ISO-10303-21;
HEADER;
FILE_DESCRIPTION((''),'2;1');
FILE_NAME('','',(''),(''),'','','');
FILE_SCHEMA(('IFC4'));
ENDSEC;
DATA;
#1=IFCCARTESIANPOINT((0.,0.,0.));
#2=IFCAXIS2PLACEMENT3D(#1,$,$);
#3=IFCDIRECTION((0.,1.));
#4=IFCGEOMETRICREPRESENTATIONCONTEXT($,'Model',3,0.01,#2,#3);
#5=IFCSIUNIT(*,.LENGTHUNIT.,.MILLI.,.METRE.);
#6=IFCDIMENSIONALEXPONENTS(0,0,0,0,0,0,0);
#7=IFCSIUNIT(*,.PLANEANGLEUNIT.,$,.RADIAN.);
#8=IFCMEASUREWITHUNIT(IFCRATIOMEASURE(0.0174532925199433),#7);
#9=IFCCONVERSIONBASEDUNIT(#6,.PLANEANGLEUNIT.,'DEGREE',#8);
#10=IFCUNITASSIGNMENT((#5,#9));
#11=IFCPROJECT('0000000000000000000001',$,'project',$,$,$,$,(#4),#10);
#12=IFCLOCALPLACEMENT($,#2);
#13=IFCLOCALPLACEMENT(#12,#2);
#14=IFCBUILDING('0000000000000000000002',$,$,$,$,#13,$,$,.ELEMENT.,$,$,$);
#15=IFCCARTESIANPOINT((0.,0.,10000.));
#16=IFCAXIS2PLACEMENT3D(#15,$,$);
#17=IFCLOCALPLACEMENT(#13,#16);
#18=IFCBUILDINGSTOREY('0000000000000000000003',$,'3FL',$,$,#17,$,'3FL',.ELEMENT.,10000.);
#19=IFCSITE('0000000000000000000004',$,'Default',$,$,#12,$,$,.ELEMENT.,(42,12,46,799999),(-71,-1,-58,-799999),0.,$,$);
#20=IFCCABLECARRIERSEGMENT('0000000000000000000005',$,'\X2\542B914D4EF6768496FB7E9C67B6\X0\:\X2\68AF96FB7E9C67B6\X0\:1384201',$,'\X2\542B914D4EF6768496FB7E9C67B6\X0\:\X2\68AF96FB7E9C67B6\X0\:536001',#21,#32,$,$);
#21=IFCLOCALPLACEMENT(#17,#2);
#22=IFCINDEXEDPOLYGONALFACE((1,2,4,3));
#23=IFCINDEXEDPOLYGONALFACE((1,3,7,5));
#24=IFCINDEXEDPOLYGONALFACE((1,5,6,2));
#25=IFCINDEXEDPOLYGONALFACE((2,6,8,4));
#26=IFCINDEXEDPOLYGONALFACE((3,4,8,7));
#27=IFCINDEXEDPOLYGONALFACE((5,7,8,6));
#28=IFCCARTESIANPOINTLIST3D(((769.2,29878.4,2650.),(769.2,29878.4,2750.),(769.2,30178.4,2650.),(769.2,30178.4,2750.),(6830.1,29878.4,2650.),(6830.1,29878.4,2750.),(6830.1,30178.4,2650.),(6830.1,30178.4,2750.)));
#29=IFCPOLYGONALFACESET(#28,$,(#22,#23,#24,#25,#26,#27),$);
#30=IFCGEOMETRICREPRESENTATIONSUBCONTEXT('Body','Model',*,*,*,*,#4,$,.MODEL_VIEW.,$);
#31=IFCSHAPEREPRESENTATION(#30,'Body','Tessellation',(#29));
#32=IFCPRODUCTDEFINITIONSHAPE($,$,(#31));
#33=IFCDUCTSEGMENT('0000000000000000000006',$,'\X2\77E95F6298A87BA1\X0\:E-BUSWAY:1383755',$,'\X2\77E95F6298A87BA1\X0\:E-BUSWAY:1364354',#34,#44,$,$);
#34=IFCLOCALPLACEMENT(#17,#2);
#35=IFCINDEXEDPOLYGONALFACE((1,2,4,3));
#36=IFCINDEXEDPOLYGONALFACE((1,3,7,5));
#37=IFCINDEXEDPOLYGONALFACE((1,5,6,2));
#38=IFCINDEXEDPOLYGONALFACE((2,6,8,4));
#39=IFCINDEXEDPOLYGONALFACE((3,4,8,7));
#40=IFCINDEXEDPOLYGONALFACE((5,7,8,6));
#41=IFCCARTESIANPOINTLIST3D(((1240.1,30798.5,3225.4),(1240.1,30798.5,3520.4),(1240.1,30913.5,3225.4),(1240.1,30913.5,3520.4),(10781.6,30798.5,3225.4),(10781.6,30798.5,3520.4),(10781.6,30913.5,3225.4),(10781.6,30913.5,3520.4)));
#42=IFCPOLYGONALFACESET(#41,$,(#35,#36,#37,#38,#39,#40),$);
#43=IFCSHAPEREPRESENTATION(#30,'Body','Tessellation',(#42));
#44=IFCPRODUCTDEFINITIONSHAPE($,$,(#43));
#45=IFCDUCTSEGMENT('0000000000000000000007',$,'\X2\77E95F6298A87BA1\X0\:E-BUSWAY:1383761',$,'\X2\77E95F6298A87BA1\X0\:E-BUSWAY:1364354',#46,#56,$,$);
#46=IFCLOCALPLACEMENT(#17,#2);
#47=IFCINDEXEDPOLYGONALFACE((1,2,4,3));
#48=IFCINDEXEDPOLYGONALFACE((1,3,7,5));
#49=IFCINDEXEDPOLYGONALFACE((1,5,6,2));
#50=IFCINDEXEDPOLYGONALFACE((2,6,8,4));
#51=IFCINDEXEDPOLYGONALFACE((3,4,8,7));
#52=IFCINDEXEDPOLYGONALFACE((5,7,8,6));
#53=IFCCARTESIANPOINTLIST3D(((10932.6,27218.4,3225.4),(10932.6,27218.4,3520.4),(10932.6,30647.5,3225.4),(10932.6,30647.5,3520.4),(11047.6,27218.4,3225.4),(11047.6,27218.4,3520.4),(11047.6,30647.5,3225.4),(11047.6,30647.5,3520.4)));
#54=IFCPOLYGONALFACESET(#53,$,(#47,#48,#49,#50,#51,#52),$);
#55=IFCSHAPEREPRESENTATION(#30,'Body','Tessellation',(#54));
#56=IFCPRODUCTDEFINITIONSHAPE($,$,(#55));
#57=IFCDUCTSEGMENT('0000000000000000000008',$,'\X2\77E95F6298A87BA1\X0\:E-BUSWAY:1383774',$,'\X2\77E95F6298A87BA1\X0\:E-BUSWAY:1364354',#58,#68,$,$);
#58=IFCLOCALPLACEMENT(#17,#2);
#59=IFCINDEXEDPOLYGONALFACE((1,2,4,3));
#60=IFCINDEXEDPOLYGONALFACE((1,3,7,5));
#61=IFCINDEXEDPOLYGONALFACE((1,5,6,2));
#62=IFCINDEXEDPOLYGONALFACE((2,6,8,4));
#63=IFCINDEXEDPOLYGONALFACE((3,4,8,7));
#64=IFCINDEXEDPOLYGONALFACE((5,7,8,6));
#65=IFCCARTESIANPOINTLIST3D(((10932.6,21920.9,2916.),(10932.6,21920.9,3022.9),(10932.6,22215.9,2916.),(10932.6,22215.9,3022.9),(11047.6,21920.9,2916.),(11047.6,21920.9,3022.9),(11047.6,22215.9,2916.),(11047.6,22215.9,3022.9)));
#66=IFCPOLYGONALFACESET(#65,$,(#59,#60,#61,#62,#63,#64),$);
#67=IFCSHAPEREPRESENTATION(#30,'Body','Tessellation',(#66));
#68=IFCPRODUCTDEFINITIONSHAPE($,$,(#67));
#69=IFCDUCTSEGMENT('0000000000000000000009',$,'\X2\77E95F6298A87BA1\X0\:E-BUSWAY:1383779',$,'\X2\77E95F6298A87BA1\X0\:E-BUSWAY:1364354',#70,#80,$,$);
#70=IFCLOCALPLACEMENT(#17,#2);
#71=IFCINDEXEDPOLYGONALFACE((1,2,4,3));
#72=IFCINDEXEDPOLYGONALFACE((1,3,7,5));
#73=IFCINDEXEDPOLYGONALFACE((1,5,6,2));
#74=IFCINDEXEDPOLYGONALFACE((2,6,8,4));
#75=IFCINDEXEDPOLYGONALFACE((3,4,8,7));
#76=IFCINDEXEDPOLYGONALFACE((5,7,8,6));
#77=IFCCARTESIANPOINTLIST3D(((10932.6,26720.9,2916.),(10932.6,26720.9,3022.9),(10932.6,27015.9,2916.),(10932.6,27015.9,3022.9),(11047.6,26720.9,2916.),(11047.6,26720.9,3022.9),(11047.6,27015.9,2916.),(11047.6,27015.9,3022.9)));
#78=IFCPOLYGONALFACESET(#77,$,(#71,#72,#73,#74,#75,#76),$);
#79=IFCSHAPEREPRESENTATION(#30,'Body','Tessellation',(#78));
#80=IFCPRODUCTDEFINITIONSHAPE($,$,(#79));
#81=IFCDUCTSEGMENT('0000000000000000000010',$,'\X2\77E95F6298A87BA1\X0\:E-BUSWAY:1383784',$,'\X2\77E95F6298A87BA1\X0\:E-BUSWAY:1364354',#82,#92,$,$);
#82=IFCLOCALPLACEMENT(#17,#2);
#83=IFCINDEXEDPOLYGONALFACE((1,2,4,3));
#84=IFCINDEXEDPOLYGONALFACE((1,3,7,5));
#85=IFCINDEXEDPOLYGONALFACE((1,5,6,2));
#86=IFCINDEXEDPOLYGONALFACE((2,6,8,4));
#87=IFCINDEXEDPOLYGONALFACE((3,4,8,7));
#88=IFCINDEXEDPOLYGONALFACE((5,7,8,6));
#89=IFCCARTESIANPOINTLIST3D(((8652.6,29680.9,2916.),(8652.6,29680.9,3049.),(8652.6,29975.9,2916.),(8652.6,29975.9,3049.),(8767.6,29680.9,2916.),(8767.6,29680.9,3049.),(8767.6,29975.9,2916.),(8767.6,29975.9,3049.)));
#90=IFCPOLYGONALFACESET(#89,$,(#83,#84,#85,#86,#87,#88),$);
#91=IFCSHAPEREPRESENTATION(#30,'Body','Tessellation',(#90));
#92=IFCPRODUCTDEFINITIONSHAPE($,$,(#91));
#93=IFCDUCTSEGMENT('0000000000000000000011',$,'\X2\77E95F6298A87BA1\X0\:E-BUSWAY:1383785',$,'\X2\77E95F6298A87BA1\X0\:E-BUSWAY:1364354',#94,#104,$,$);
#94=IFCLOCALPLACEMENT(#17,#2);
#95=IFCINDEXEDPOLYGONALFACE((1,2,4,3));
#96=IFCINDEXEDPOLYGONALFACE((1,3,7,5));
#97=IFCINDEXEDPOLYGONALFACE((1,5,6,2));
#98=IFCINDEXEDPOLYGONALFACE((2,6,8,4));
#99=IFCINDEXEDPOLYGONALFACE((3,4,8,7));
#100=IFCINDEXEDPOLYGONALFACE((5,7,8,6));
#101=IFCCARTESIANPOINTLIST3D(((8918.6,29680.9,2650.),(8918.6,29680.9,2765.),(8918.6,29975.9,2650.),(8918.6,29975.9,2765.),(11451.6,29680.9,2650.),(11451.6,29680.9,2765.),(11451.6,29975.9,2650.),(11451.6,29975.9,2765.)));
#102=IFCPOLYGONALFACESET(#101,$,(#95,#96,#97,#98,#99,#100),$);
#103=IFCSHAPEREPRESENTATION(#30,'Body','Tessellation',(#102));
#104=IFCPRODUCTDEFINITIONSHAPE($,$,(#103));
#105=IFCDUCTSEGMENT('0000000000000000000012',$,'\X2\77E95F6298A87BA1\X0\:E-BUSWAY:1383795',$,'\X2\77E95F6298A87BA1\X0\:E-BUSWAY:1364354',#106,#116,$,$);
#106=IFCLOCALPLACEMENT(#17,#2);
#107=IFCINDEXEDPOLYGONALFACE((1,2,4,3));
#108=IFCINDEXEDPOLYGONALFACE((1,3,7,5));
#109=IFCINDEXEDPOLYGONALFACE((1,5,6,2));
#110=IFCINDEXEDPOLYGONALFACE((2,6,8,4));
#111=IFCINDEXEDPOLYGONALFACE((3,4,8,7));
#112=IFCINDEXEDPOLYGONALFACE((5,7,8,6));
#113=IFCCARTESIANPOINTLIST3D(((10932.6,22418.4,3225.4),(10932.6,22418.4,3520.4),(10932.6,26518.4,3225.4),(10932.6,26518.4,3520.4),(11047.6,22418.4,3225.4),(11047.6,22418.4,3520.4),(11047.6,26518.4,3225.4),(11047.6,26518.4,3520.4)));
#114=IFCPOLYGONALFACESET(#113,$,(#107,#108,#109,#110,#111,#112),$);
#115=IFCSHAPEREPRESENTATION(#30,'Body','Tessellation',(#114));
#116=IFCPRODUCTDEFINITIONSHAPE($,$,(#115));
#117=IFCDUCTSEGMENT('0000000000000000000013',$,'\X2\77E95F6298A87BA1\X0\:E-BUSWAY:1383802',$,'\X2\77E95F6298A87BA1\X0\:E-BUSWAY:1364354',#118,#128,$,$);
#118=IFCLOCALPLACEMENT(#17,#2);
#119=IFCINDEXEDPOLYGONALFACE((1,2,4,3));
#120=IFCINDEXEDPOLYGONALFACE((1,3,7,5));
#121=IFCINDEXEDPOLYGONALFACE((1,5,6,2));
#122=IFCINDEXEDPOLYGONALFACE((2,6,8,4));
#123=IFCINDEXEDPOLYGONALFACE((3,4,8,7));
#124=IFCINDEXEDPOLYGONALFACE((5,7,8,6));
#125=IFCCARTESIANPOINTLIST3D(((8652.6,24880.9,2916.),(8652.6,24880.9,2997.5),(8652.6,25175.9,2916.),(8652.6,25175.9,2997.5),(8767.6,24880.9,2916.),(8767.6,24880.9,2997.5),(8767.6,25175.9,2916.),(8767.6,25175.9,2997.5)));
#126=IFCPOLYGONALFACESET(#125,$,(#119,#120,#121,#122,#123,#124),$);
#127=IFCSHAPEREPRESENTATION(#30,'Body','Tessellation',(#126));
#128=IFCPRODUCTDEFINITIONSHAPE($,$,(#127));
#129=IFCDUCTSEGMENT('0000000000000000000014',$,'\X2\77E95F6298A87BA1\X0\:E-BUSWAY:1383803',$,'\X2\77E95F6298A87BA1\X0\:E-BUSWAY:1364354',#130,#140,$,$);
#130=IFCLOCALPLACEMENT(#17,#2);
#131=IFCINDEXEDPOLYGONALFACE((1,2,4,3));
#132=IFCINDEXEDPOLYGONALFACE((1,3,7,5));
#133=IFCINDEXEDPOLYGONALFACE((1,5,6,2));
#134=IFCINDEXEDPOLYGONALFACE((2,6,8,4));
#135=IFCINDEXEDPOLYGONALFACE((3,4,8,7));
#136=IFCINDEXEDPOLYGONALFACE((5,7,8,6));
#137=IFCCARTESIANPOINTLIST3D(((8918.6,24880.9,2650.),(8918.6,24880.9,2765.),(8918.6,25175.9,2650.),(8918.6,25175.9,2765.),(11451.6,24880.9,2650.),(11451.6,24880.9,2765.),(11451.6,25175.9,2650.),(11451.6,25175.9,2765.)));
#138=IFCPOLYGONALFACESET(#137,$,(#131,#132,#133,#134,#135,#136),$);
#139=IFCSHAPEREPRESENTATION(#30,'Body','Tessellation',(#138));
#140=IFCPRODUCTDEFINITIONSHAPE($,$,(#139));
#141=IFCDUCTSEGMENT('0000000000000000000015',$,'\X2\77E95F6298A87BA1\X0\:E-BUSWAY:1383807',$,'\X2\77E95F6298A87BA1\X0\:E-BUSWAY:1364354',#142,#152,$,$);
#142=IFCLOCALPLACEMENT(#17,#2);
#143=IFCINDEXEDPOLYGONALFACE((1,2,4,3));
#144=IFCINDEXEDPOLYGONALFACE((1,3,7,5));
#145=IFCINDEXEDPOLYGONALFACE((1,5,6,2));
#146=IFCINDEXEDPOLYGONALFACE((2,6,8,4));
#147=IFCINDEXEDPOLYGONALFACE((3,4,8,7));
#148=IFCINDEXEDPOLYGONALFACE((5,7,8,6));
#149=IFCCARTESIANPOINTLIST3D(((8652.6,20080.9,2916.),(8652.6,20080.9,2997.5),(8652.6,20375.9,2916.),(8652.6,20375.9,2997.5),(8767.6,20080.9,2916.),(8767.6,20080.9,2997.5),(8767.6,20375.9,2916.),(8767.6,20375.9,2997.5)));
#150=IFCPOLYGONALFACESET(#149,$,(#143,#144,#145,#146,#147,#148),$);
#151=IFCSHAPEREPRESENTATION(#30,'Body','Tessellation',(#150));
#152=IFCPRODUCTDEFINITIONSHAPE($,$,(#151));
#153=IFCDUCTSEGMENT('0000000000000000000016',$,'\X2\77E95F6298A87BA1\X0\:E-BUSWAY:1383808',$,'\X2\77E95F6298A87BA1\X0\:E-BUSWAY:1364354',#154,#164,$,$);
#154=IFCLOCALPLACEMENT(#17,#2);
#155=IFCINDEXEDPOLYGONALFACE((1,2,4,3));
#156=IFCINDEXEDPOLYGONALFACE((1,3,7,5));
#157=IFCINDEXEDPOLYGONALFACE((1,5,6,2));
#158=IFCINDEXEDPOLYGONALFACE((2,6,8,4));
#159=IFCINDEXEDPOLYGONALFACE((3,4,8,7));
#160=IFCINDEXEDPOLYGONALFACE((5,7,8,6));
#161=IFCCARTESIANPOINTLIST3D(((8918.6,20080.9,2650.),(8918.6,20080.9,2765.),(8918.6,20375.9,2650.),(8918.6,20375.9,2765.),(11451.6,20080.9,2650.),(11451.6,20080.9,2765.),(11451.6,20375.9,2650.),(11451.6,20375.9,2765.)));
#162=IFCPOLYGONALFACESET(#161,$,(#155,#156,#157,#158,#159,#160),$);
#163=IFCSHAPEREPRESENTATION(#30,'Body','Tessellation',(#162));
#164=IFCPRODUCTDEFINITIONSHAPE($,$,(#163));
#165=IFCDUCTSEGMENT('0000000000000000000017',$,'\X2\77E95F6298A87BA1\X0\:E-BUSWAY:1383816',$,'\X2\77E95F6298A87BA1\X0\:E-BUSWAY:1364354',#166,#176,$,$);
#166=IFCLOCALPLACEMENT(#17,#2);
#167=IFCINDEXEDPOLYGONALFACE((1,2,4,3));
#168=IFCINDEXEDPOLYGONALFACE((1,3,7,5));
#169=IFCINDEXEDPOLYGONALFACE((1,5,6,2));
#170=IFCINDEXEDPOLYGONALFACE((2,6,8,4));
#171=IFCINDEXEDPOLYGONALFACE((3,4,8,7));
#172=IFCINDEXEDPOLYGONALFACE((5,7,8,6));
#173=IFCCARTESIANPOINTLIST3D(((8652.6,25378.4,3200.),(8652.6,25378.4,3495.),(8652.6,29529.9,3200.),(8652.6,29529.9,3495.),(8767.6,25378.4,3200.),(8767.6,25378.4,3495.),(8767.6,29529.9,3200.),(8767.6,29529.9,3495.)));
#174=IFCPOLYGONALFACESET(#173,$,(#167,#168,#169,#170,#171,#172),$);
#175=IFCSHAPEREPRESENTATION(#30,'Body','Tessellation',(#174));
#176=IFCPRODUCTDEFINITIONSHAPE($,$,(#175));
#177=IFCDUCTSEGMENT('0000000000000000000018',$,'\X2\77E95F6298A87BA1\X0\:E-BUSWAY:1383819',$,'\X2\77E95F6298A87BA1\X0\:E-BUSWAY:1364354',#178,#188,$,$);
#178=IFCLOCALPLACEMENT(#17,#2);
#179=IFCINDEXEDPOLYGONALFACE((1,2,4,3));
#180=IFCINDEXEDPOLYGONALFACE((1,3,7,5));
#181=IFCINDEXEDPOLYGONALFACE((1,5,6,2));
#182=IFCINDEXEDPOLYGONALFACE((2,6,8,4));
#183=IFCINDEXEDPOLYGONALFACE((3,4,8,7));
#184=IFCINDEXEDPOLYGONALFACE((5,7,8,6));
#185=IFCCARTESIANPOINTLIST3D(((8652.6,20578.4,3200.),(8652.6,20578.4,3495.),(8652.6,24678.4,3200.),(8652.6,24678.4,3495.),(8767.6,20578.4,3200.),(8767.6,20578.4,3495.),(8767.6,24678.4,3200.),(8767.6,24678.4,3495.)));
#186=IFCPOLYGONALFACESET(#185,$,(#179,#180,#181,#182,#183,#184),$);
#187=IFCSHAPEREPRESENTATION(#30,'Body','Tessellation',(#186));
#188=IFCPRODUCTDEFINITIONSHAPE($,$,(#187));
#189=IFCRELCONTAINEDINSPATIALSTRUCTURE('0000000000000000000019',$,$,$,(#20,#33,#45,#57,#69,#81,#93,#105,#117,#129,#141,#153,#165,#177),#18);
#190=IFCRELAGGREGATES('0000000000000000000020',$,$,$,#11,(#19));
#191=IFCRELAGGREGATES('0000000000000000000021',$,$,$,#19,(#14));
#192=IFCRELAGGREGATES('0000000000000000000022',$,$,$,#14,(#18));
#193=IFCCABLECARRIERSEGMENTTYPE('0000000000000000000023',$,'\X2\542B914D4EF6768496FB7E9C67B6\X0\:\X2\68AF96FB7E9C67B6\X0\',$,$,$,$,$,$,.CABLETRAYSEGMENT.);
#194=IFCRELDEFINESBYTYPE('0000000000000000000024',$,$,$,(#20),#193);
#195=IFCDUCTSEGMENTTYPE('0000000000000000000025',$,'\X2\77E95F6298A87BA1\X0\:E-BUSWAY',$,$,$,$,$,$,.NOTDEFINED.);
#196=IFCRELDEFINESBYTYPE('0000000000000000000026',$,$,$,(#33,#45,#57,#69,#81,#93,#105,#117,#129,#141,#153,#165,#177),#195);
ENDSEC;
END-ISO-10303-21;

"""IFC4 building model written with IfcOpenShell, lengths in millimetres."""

from ifc_helpers import new_model, entity, si_unit, converted_unit, direction, frame, frame_2d, origin, origin_2d_with_axis, place, context, subcontext, project, spatial, rectangle, extrude, type_object, element, save


model = new_model("IFC4")

# Units and contexts
model_context = context("Model", 3, precision=0.01, world=origin(), true_north=direction((0.0, 1.0)))
body_context = subcontext(model_context, "Body", "Model", "MODEL_VIEW")
ifc_project = project(units=[si_unit("LENGTHUNIT", "METRE", prefix="MILLI"), converted_unit("PLANEANGLEUNIT", "DEGREE", entity("IfcRatioMeasure", 0.0174532925199433), si_unit("PLANEANGLEUNIT", "RADIAN"), dimensions=[0, 0, 0, 0, 0, 0, 0])], contexts=[model_context])

# Site, building, storey
site_placement = place(None, origin())
site = spatial("IfcSite", under=ifc_project, at=site_placement, Name="Default", CompositionType="ELEMENT", RefLatitude=(42, 12, 46, 799999), RefLongitude=(-71, -1, -58, -799999), RefElevation=0.0)
building_placement = place(site_placement, origin())
building = spatial("IfcBuilding", under=site, at=building_placement, CompositionType="ELEMENT")
storey_placement = place(building_placement, frame((0.0, 0.0, 10000.0)))
storey = spatial("IfcBuildingStorey", under=building, at=storey_placement, Name="3FL", LongName="3FL", CompositionType="ELEMENT", Elevation=10000.0)

# Cable carrier segment
cable_carrier_segment_type = type_object("IfcCableCarrierSegmentType", Name="含配件的電纜架:梯電纜架", PredefinedType="CABLETRAYSEGMENT")
cable_carrier_segment_placement = place(storey_placement, frame((769.2, 29878.4, 2650.0)))
element("IfcCableCarrierSegment", 1, at=cable_carrier_segment_placement, inside=storey, type_object=cable_carrier_segment_type, Name="含配件的電纜架:梯電纜架:1384201", ObjectType="含配件的電纜架:梯電纜架:536001", context=body_context, shape_type="SweptSolid", body=[
    extrude(rectangle(XDim=300.0, YDim=6060.9, at=frame_2d((0.0, 0.0), x_axis=(1.0, 0.0))), frame((3030.5, 150.0, 0.0), z_axis=(0.0, 0.0, 1.0), x_axis=(0.0, -1.0, 0.0)), (0.0, 0.0, 1.0), 100.0),
])

# Duct segments
duct_segment_type = type_object("IfcDuctSegmentType", Name="矩形風管:E-BUSWAY", PredefinedType="NOTDEFINED")
duct_segment_1_placement = place(storey_placement, frame((1240.1, 30798.5, 3225.4)))
element("IfcDuctSegment", 2, at=duct_segment_1_placement, inside=storey, type_object=duct_segment_type, Name="矩形風管:E-BUSWAY:1383755", ObjectType="矩形風管:E-BUSWAY:1364354", context=body_context, shape_type="SweptSolid", body=[
    extrude(rectangle(XDim=9541.5, YDim=115.0, at=frame_2d((0.0, 0.0), x_axis=(1.0, 0.0))), frame((4770.8, 57.5, 0.0), z_axis=(0.0, 0.0, 1.0), x_axis=(-1.0, 0.0, 0.0)), (0.0, 0.0, 1.0), 295.0),
])
duct_segment_2_placement = place(storey_placement, frame((10932.6, 27218.4, 3225.4)))
element("IfcDuctSegment", 3, at=duct_segment_2_placement, inside=storey, type_object=duct_segment_type, Name="矩形風管:E-BUSWAY:1383761", ObjectType="矩形風管:E-BUSWAY:1364354", context=body_context, shape_type="SweptSolid", body=[
    extrude(rectangle(XDim=3429.1, YDim=115.0, at=frame_2d((0.0, 0.0), x_axis=(1.0, 0.0))), frame((57.5, 1714.5, 0.0), z_axis=(0.0, 0.0, 1.0), x_axis=(0.0, 1.0, 0.0)), (0.0, 0.0, 1.0), 295.0),
])
duct_segment_3_placement = place(storey_placement, frame((10932.6, 21920.9, 2916.0)))
element("IfcDuctSegment", 4, at=duct_segment_3_placement, inside=storey, type_object=duct_segment_type, Name="矩形風管:E-BUSWAY:1383774", ObjectType="矩形風管:E-BUSWAY:1364354", context=body_context, shape_type="SweptSolid", body=[
    extrude(rectangle(XDim=115.0, YDim=295.0, at=frame_2d((0.0, 0.0), x_axis=(1.0, 0.0))), frame((57.5, 147.5, 0.0), z_axis=(0.0, 0.0, 1.0), x_axis=(-1.0, 0.0, 0.0)), (0.0, 0.0, 1.0), 106.9),
])
duct_segment_4_placement = place(storey_placement, frame((10932.6, 26720.9, 2916.0)))
element("IfcDuctSegment", 5, at=duct_segment_4_placement, inside=storey, type_object=duct_segment_type, Name="矩形風管:E-BUSWAY:1383779", ObjectType="矩形風管:E-BUSWAY:1364354", context=body_context, shape_type="SweptSolid", body=[
    extrude(rectangle(XDim=115.0, YDim=295.0, at=frame_2d((0.0, 0.0), x_axis=(1.0, 0.0))), frame((57.5, 147.5, 0.0), z_axis=(0.0, 0.0, 1.0), x_axis=(-1.0, 0.0, 0.0)), (0.0, 0.0, 1.0), 106.9),
])
duct_segment_5_placement = place(storey_placement, frame((8652.6, 29680.9, 2916.0)))
element("IfcDuctSegment", 6, at=duct_segment_5_placement, inside=storey, type_object=duct_segment_type, Name="矩形風管:E-BUSWAY:1383784", ObjectType="矩形風管:E-BUSWAY:1364354", context=body_context, shape_type="SweptSolid", body=[
    extrude(rectangle(XDim=115.0, YDim=295.0, at=frame_2d((0.0, 0.0), x_axis=(1.0, 0.0))), frame((57.5, 147.5, 0.0), z_axis=(0.0, 0.0, 1.0), x_axis=(-1.0, 0.0, 0.0)), (0.0, 0.0, 1.0), 133.0),
])
duct_segment_6_placement = place(storey_placement, frame((8918.6, 29680.9, 2650.0)))
element("IfcDuctSegment", 7, at=duct_segment_6_placement, inside=storey, type_object=duct_segment_type, Name="矩形風管:E-BUSWAY:1383785", ObjectType="矩形風管:E-BUSWAY:1364354", context=body_context, shape_type="SweptSolid", body=[
    extrude(rectangle(XDim=2533.0, YDim=295.0, at=frame_2d((0.0, 0.0), x_axis=(1.0, 0.0))), frame((1266.5, 147.5, 0.0)), (0.0, 0.0, 1.0), 115.0),
])
duct_segment_7_placement = place(storey_placement, frame((10932.6, 22418.4, 3225.4)))
element("IfcDuctSegment", 8, at=duct_segment_7_placement, inside=storey, type_object=duct_segment_type, Name="矩形風管:E-BUSWAY:1383795", ObjectType="矩形風管:E-BUSWAY:1364354", context=body_context, shape_type="SweptSolid", body=[
    extrude(rectangle(XDim=4100.0, YDim=115.0, at=frame_2d((0.0, 0.0), x_axis=(1.0, 0.0))), frame((57.5, 2050.0, 0.0), z_axis=(0.0, 0.0, 1.0), x_axis=(0.0, 1.0, 0.0)), (0.0, 0.0, 1.0), 295.0),
])
duct_segment_8_placement = place(storey_placement, frame((8652.6, 24880.9, 2916.0)))
element("IfcDuctSegment", 9, at=duct_segment_8_placement, inside=storey, type_object=duct_segment_type, Name="矩形風管:E-BUSWAY:1383802", ObjectType="矩形風管:E-BUSWAY:1364354", context=body_context, shape_type="SweptSolid", body=[
    extrude(rectangle(XDim=115.0, YDim=295.0, at=frame_2d((0.0, 0.0), x_axis=(1.0, 0.0))), frame((57.5, 147.5, 0.0), z_axis=(0.0, 0.0, 1.0), x_axis=(-1.0, 0.0, 0.0)), (0.0, 0.0, 1.0), 81.5),
])
duct_segment_9_placement = place(storey_placement, frame((8918.6, 24880.9, 2650.0)))
element("IfcDuctSegment", 10, at=duct_segment_9_placement, inside=storey, type_object=duct_segment_type, Name="矩形風管:E-BUSWAY:1383803", ObjectType="矩形風管:E-BUSWAY:1364354", context=body_context, shape_type="SweptSolid", body=[
    extrude(rectangle(XDim=2533.0, YDim=295.0, at=frame_2d((0.0, 0.0), x_axis=(1.0, 0.0))), frame((1266.5, 147.5, 0.0)), (0.0, 0.0, 1.0), 115.0),
])
duct_segment_10_placement = place(storey_placement, frame((8652.6, 20080.9, 2916.0)))
element("IfcDuctSegment", 11, at=duct_segment_10_placement, inside=storey, type_object=duct_segment_type, Name="矩形風管:E-BUSWAY:1383807", ObjectType="矩形風管:E-BUSWAY:1364354", context=body_context, shape_type="SweptSolid", body=[
    extrude(rectangle(XDim=115.0, YDim=295.0, at=frame_2d((0.0, 0.0), x_axis=(1.0, 0.0))), frame((57.5, 147.5, 0.0), z_axis=(0.0, 0.0, 1.0), x_axis=(-1.0, 0.0, 0.0)), (0.0, 0.0, 1.0), 81.5),
])
duct_segment_11_placement = place(storey_placement, frame((8918.6, 20080.9, 2650.0)))
element("IfcDuctSegment", 12, at=duct_segment_11_placement, inside=storey, type_object=duct_segment_type, Name="矩形風管:E-BUSWAY:1383808", ObjectType="矩形風管:E-BUSWAY:1364354", context=body_context, shape_type="SweptSolid", body=[
    extrude(rectangle(XDim=2533.0, YDim=295.0, at=origin_2d_with_axis()), frame((1266.5, 147.5, 0.0)), (0.0, 0.0, 1.0), 115.0),
])
duct_segment_12_placement = place(storey_placement, frame((8652.6, 25378.4, 3200.0)))
element("IfcDuctSegment", 13, at=duct_segment_12_placement, inside=storey, type_object=duct_segment_type, Name="矩形風管:E-BUSWAY:1383816", ObjectType="矩形風管:E-BUSWAY:1364354", context=body_context, shape_type="SweptSolid", body=[
    extrude(rectangle(XDim=4151.5, YDim=115.0, at=origin_2d_with_axis()), frame((57.5, 2075.7, 0.0), z_axis=(0.0, 0.0, 1.0), x_axis=(0.0, -1.0, 0.0)), (0.0, 0.0, 1.0), 295.0),
])
duct_segment_13_placement = place(storey_placement, frame((8652.6, 20578.4, 3200.0)))
element("IfcDuctSegment", 14, at=duct_segment_13_placement, inside=storey, type_object=duct_segment_type, Name="矩形風管:E-BUSWAY:1383819", ObjectType="矩形風管:E-BUSWAY:1364354", context=body_context, shape_type="SweptSolid", body=[
    extrude(rectangle(XDim=4100.0, YDim=115.0, at=origin_2d_with_axis()), frame((57.5, 2050.0, 0.0), z_axis=(0.0, 0.0, 1.0), x_axis=(0.0, -1.0, 0.0)), (0.0, 0.0, 1.0), 295.0),
])

save(model, "model.ifc")
